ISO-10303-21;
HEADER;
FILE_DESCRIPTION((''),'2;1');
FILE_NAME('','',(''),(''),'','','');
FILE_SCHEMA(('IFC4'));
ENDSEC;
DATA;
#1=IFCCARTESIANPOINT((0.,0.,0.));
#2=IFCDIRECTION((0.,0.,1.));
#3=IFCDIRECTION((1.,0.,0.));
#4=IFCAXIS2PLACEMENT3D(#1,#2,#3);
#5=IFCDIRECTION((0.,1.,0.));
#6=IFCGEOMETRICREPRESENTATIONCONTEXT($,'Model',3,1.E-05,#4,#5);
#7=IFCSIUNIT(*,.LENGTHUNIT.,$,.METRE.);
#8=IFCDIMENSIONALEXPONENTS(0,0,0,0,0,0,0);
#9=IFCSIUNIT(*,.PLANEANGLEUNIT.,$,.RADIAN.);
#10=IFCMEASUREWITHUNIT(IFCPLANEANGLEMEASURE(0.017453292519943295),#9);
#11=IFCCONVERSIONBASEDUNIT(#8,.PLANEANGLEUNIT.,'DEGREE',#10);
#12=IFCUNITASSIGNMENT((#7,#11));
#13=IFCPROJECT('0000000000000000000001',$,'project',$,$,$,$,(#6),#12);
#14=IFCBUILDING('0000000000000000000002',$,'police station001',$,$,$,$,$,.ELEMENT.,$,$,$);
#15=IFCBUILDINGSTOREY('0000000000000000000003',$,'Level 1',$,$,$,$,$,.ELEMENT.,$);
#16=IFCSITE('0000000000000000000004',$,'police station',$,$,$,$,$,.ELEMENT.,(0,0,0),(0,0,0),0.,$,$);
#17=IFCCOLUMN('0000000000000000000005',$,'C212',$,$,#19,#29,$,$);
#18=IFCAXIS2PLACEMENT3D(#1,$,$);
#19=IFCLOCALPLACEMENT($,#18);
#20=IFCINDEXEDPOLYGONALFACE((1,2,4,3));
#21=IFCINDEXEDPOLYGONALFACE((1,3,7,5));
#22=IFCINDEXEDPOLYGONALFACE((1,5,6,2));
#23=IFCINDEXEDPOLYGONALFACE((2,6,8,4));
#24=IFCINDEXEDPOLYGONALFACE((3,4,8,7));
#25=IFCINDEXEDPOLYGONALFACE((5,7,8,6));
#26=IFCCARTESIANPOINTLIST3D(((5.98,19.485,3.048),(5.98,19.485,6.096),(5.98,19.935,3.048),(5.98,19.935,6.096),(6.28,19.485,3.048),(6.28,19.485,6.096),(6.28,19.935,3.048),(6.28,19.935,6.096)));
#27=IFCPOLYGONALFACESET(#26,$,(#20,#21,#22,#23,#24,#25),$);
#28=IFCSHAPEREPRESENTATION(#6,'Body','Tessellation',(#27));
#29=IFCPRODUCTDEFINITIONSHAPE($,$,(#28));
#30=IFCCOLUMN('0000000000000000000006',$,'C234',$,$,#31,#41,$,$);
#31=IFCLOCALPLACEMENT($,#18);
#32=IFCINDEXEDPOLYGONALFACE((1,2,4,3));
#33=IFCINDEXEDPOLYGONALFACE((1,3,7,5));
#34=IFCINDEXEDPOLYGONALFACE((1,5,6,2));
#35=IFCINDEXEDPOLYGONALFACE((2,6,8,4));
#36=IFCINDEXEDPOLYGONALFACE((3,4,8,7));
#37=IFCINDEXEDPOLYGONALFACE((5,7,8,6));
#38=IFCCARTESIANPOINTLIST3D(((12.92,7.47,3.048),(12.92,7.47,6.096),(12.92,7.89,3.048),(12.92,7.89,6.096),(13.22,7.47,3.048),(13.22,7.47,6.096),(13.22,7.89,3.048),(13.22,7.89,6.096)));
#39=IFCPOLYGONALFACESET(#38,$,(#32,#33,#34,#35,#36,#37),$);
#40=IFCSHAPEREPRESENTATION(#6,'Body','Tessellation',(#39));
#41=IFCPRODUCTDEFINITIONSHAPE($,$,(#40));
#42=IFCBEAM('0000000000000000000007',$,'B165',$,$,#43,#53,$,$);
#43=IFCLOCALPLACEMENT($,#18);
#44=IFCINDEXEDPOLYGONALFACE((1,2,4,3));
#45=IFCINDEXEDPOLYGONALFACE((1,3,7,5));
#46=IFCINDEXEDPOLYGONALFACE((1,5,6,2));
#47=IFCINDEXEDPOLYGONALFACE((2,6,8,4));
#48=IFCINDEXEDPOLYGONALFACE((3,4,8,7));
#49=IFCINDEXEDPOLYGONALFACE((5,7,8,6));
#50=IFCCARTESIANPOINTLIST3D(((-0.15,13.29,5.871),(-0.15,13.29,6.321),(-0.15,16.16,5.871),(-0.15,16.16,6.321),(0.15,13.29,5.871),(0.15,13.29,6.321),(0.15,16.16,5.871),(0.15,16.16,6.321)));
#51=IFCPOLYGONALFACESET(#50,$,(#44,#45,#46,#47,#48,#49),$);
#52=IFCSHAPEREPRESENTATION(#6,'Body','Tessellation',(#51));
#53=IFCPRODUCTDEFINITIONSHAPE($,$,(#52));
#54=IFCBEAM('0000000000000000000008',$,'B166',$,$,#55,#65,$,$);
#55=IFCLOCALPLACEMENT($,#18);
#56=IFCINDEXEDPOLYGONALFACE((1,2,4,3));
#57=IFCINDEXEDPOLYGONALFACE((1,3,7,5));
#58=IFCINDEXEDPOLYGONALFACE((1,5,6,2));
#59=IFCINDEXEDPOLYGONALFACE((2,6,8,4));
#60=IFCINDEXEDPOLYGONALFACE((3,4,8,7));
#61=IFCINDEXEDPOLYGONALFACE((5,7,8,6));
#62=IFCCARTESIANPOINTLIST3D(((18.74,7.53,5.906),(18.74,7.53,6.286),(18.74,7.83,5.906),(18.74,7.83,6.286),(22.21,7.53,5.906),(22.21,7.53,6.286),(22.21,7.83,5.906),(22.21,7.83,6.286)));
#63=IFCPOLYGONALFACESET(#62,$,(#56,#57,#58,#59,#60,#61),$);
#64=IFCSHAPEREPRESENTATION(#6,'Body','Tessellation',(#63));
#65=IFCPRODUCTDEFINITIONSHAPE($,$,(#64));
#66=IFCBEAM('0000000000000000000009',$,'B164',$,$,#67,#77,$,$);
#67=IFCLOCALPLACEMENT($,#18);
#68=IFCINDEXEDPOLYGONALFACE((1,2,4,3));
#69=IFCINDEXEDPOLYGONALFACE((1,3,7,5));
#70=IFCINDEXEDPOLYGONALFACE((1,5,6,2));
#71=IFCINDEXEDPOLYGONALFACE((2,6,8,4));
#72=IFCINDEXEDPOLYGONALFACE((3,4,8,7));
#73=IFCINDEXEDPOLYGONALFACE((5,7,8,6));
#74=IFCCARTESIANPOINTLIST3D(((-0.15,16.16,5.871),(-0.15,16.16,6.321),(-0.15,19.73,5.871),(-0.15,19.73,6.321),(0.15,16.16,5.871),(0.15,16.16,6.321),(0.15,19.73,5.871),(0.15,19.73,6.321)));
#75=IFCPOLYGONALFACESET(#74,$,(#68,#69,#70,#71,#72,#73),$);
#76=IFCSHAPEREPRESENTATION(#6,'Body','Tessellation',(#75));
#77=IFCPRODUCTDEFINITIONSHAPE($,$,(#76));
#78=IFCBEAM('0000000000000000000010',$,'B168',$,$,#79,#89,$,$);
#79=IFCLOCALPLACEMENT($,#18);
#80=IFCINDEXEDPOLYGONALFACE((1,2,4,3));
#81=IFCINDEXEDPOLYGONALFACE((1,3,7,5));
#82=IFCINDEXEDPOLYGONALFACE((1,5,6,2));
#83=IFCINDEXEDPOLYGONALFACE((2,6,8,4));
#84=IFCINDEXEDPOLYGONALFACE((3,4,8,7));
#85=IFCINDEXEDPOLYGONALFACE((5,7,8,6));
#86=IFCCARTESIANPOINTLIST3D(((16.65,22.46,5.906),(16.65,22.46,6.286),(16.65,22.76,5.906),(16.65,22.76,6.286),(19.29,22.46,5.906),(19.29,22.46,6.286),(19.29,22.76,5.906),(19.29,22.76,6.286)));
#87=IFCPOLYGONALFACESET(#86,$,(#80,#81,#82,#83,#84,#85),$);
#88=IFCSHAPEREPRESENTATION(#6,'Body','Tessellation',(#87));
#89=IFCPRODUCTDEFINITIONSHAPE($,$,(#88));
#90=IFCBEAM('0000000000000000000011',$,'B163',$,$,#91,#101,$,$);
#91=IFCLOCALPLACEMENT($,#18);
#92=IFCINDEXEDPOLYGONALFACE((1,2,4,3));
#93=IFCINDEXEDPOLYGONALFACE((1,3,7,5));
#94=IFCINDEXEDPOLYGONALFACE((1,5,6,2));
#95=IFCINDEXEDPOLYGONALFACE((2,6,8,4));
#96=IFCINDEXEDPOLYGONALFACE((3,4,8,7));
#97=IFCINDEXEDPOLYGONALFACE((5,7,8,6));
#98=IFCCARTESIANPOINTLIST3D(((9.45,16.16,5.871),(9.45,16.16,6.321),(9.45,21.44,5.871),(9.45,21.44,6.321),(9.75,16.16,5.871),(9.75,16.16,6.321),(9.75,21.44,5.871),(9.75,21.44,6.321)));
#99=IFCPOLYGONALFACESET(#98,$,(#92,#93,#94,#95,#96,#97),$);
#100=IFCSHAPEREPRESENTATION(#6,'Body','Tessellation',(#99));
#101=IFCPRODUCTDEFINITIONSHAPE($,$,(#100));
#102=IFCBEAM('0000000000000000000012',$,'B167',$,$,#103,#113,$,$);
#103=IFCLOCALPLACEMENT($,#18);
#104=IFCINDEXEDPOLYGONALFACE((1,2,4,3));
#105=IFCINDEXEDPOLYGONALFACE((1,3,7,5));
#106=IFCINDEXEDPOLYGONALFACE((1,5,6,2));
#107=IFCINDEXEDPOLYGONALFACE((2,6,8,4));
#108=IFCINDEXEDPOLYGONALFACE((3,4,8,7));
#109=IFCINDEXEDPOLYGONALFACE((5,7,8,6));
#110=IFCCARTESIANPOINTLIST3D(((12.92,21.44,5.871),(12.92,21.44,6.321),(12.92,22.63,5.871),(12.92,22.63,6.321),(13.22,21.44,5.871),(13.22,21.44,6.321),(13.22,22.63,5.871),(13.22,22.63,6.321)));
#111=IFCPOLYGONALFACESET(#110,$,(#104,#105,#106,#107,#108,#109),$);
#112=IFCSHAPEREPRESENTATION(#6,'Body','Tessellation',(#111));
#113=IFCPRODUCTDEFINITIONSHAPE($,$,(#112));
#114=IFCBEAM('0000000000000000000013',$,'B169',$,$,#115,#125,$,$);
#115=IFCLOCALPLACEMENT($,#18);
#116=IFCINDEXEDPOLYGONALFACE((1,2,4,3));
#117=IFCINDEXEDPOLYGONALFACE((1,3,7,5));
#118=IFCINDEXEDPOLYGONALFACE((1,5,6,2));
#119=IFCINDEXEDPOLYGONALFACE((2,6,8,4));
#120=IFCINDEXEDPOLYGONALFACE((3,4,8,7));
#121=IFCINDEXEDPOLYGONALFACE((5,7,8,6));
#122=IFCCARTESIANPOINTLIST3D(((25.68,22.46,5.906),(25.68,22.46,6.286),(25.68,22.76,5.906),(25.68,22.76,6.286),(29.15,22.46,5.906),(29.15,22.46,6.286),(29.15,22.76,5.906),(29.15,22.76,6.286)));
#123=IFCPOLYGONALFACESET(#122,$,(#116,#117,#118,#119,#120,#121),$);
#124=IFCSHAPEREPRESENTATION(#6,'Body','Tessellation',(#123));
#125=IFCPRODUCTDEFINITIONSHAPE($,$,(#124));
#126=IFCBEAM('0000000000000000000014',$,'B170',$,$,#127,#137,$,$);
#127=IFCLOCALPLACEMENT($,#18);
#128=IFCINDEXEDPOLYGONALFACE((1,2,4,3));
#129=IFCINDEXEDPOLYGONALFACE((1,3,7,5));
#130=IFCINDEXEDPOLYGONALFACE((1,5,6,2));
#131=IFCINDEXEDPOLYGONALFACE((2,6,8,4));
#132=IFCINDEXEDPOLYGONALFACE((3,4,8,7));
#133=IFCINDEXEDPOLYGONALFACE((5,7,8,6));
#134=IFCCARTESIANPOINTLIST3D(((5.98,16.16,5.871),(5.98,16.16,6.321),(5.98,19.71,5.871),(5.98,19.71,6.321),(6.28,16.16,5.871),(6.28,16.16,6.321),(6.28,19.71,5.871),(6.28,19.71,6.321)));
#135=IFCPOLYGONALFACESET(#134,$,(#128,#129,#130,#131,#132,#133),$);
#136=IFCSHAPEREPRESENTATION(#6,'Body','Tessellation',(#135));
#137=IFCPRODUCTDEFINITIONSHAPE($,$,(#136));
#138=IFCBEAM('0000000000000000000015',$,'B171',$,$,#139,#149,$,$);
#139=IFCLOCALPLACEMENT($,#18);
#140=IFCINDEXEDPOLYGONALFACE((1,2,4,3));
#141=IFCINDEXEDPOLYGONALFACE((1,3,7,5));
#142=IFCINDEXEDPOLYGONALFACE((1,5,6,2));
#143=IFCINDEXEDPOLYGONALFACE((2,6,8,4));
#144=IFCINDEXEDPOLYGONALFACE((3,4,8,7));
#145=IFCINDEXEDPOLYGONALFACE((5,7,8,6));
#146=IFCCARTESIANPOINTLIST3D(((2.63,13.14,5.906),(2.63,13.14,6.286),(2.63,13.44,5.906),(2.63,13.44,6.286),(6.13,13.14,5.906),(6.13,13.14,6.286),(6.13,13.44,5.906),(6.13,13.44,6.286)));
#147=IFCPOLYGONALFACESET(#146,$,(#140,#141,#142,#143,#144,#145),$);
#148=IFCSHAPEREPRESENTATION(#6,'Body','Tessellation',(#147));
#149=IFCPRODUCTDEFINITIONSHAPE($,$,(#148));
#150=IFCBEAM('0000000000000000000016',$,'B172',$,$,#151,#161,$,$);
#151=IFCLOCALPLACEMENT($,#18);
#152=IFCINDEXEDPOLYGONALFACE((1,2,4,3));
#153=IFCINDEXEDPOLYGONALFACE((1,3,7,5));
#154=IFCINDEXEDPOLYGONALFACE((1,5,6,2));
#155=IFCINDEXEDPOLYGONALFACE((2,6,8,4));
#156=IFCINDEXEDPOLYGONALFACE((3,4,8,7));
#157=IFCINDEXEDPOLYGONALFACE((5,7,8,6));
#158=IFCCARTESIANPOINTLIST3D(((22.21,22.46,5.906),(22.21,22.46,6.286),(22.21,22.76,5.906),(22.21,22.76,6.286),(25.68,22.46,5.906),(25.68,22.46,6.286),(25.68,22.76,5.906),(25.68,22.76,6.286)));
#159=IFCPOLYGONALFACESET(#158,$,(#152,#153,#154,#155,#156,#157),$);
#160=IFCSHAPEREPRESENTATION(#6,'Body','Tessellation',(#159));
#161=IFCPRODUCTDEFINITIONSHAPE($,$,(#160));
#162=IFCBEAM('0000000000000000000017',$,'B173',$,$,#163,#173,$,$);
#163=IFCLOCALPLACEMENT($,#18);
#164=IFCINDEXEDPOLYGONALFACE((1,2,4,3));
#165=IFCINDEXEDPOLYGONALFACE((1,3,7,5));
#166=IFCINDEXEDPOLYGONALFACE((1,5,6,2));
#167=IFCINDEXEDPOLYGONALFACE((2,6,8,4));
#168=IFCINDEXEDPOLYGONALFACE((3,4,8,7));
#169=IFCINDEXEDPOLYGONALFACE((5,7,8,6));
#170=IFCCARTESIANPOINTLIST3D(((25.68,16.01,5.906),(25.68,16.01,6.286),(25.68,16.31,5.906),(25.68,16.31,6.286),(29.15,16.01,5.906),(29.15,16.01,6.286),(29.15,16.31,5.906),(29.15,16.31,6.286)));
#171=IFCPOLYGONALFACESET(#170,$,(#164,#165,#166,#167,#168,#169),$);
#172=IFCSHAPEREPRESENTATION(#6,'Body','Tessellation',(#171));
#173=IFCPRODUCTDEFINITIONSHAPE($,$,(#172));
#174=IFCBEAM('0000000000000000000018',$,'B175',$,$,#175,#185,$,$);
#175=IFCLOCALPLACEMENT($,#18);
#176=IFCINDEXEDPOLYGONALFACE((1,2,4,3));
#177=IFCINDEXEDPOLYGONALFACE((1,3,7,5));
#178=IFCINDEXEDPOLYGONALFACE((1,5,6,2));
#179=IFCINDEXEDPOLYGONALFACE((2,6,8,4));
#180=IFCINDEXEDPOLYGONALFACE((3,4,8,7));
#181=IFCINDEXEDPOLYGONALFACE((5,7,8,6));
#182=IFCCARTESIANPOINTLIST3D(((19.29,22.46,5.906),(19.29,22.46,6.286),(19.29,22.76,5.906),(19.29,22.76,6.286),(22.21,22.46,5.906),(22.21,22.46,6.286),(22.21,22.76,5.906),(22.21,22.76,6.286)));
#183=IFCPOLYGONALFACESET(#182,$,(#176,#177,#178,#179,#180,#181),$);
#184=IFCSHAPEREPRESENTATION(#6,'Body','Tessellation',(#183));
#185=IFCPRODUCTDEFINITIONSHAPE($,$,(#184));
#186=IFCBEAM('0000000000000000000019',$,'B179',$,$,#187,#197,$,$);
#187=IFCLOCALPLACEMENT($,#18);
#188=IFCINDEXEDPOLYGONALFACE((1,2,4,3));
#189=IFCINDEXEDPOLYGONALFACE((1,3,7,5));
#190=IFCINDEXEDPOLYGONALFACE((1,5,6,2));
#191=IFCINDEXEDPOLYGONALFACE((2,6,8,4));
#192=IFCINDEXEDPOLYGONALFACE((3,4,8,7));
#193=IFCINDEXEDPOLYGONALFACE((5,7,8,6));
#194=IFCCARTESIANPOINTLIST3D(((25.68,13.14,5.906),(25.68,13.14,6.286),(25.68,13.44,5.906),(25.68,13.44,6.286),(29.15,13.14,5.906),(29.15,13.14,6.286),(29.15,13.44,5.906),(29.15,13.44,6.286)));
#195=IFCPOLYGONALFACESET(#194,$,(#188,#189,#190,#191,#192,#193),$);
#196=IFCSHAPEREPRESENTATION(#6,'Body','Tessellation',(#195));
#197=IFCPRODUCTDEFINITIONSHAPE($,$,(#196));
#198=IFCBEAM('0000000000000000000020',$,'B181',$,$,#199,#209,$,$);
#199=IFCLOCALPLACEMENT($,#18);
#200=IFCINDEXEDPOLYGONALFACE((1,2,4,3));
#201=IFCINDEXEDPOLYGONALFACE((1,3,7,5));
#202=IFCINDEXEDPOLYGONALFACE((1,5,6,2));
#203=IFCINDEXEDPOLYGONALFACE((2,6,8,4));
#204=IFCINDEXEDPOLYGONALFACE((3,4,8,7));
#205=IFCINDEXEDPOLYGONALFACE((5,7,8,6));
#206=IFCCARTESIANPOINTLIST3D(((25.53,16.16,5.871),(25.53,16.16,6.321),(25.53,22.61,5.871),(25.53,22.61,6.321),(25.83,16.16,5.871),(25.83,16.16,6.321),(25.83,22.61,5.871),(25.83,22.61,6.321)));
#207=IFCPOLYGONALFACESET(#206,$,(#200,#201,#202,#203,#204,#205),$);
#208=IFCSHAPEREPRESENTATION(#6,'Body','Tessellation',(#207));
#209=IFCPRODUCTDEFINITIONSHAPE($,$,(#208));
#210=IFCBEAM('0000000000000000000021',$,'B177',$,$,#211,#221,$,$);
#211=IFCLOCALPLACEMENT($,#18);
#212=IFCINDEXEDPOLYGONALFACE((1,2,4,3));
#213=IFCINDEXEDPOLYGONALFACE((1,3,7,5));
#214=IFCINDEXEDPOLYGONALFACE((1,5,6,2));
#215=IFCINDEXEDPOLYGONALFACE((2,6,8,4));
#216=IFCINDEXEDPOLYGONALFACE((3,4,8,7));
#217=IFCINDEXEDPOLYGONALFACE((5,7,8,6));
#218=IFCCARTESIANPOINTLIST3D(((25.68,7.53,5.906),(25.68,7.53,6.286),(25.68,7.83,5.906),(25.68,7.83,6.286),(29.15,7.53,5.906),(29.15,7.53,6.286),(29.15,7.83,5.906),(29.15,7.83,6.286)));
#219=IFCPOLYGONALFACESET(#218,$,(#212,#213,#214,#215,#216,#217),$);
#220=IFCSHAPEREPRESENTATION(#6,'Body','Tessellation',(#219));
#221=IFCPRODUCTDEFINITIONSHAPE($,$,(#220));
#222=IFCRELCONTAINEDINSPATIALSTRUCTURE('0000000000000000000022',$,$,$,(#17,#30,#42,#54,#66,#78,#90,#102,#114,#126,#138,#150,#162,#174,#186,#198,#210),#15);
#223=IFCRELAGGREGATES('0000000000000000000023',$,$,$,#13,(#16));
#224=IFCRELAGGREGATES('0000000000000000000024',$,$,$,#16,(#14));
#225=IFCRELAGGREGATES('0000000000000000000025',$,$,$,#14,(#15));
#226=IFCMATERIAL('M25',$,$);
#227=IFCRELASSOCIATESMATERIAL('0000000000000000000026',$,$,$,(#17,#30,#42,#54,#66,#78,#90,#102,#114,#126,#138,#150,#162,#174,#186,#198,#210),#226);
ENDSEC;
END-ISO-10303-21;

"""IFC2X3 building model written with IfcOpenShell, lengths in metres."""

from ifc_helpers import new_model, entity, si_unit, converted_unit, direction, frame, frame_2d, origin_with_axes, place, context, project, spatial, rectangle, extrude, material, element, save


model = new_model("IFC2X3")

# Units and contexts
model_context = context("Model", 3, precision=1e-05, world=origin_with_axes(), true_north=direction((0.0, 1.0, 0.0)))
ifc_project = project(units=[si_unit("LENGTHUNIT", "METRE"), converted_unit("PLANEANGLEUNIT", "DEGREE", entity("IfcPlaneAngleMeasure", 0.017453292519943295), si_unit("PLANEANGLEUNIT", "RADIAN"), dimensions=[0, 0, 0, 0, 0, 0, 0])], contexts=[model_context])

# Site, building, storey
site = spatial("IfcSite", under=ifc_project, Name="police station", CompositionType="ELEMENT", RefLatitude=(0, 0, 0), RefLongitude=(0, 0, 0), RefElevation=0.0)
building = spatial("IfcBuilding", under=site, Name="police station001", CompositionType="ELEMENT")
storey = spatial("IfcBuildingStorey", under=building, Name="Level 1", CompositionType="ELEMENT")

# Columns
ifc_material = material(Name="M25")
placement = place(None, origin_with_axes())
element("IfcColumn", 1, at=placement, inside=storey, material=ifc_material, Name="C212", context=model_context, shape_type="SweptSolid", body=[
    extrude(rectangle(XDim=0.3, YDim=0.45, at=frame_2d((0.0, 0.0), x_axis=(1.0, 0.0, 0.0))), frame((6.13, 19.71, 3.048), z_axis=(0.0, 0.0, 1.0), x_axis=(1.0, 0.0, 0.0)), (0.0, 0.0, 1.0), 3.048),
])
element("IfcColumn", 2, at=placement, inside=storey, material=ifc_material, Name="C234", context=model_context, shape_type="SweptSolid", body=[
    extrude(rectangle(XDim=0.3, YDim=0.42, at=frame_2d((0.0, 0.0), x_axis=(1.0, 0.0, 0.0))), frame((13.07, 7.68, 3.048), z_axis=(0.0, 0.0, 1.0), x_axis=(1.0, 0.0, 0.0)), (0.0, 0.0, 1.0), 3.048),
])

# Beams
element("IfcBeam", 3, at=placement, inside=storey, material=ifc_material, Name="B165", context=model_context, shape_type="SweptSolid", body=[
    extrude(rectangle(XDim=0.3, YDim=0.45, at=frame_2d((0.0, 0.0), x_axis=(0.0, 1.0, 0.0))), frame((0.0, 13.29, 6.096), z_axis=(0.0, 1.0, 0.0), x_axis=(0.0, 0.0, -1.0)), (0.0, 0.0, 1.0), 2.87),
])
element("IfcBeam", 4, at=placement, inside=storey, material=ifc_material, Name="B166", context=model_context, shape_type="SweptSolid", body=[
    extrude(rectangle(XDim=0.3, YDim=0.38, at=frame_2d((0.0, 0.0), x_axis=(0.0, 1.0, 0.0))), frame((18.74, 7.68, 6.096), z_axis=(1.0, 0.0, 0.0), x_axis=(0.0, 0.0, -1.0)), (0.0, 0.0, 1.0), 3.47),
])
element("IfcBeam", 5, at=placement, inside=storey, material=ifc_material, Name="B164", context=model_context, shape_type="SweptSolid", body=[
    extrude(rectangle(XDim=0.3, YDim=0.45, at=frame_2d((0.0, 0.0), x_axis=(0.0, 1.0, 0.0))), frame((0.0, 19.73, 6.096), z_axis=(0.0, -1.0, 0.0), x_axis=(0.0, 0.0, -1.0)), (0.0, 0.0, 1.0), 3.57),
])
element("IfcBeam", 6, at=placement, inside=storey, material=ifc_material, Name="B168", context=model_context, shape_type="SweptSolid", body=[
    extrude(rectangle(XDim=0.3, YDim=0.38, at=frame_2d((0.0, 0.0), x_axis=(0.0, 1.0, 0.0))), frame((19.29, 22.61, 6.096), z_axis=(-1.0, 0.0, 0.0), x_axis=(0.0, 0.0, -1.0)), (0.0, 0.0, 1.0), 2.64),
])
element("IfcBeam", 7, at=placement, inside=storey, material=ifc_material, Name="B163", context=model_context, shape_type="SweptSolid", body=[
    extrude(rectangle(XDim=0.3, YDim=0.45, at=frame_2d((0.0, 0.0), x_axis=(0.0, 1.0, 0.0))), frame((9.6, 16.16, 6.096), z_axis=(0.0, 1.0, 0.0), x_axis=(0.0, 0.0, -1.0)), (0.0, 0.0, 1.0), 5.28),
])
element("IfcBeam", 8, at=placement, inside=storey, material=ifc_material, Name="B167", context=model_context, shape_type="SweptSolid", body=[
    extrude(rectangle(XDim=0.3, YDim=0.45, at=frame_2d((0.0, 0.0), x_axis=(0.0, 1.0, 0.0))), frame((13.07, 21.44, 6.096), z_axis=(0.0, 1.0, 0.0), x_axis=(0.0, 0.0, -1.0)), (0.0, 0.0, 1.0), 1.19),
])
element("IfcBeam", 9, at=placement, inside=storey, material=ifc_material, Name="B169", context=model_context, shape_type="SweptSolid", body=[
    extrude(rectangle(XDim=0.3, YDim=0.38, at=frame_2d((0.0, 0.0), x_axis=(0.0, 1.0, 0.0))), frame((29.15, 22.61, 6.096), z_axis=(-1.0, 0.0, 0.0), x_axis=(0.0, 0.0, -1.0)), (0.0, 0.0, 1.0), 3.47),
])
element("IfcBeam", 10, at=placement, inside=storey, material=ifc_material, Name="B170", context=model_context, shape_type="SweptSolid", body=[
    extrude(rectangle(XDim=0.3, YDim=0.45, at=frame_2d((0.0, 0.0), x_axis=(0.0, 1.0, 0.0))), frame((6.13, 16.16, 6.096), z_axis=(0.0, 1.0, 0.0), x_axis=(0.0, 0.0, -1.0)), (0.0, 0.0, 1.0), 3.55),
])
element("IfcBeam", 11, at=placement, inside=storey, material=ifc_material, Name="B171", context=model_context, shape_type="SweptSolid", body=[
    extrude(rectangle(XDim=0.3, YDim=0.38, at=frame_2d((0.0, 0.0), x_axis=(0.0, 1.0, 0.0))), frame((2.63, 13.29, 6.096), z_axis=(1.0, 0.0, 0.0), x_axis=(0.0, 0.0, -1.0)), (0.0, 0.0, 1.0), 3.5),
])
element("IfcBeam", 12, at=placement, inside=storey, material=ifc_material, Name="B172", context=model_context, shape_type="SweptSolid", body=[
    extrude(rectangle(XDim=0.3, YDim=0.38, at=frame_2d((0.0, 0.0), x_axis=(0.0, 1.0, 0.0))), frame((25.68, 22.61, 6.096), z_axis=(-1.0, 0.0, 0.0), x_axis=(0.0, 0.0, -1.0)), (0.0, 0.0, 1.0), 3.47),
])
element("IfcBeam", 13, at=placement, inside=storey, material=ifc_material, Name="B173", context=model_context, shape_type="SweptSolid", body=[
    extrude(rectangle(XDim=0.3, YDim=0.38, at=frame_2d((0.0, 0.0), x_axis=(0.0, 1.0, 0.0))), frame((25.68, 16.16, 6.096), z_axis=(1.0, 0.0, 0.0), x_axis=(0.0, 0.0, -1.0)), (0.0, 0.0, 1.0), 3.47),
])
element("IfcBeam", 14, at=placement, inside=storey, material=ifc_material, Name="B175", context=model_context, shape_type="SweptSolid", body=[
    extrude(rectangle(XDim=0.3, YDim=0.38, at=frame_2d((0.0, 0.0), x_axis=(0.0, 1.0, 0.0))), frame((22.21, 22.61, 6.096), z_axis=(-1.0, 0.0, 0.0), x_axis=(0.0, 0.0, -1.0)), (0.0, 0.0, 1.0), 2.92),
])
element("IfcBeam", 15, at=placement, inside=storey, material=ifc_material, Name="B179", context=model_context, shape_type="SweptSolid", body=[
    extrude(rectangle(XDim=0.3, YDim=0.38, at=frame_2d((0.0, 0.0), x_axis=(0.0, 1.0, 0.0))), frame((29.15, 13.29, 6.096), z_axis=(-1.0, 0.0, 0.0), x_axis=(0.0, 0.0, -1.0)), (0.0, 0.0, 1.0), 3.47),
])
element("IfcBeam", 16, at=placement, inside=storey, material=ifc_material, Name="B181", context=model_context, shape_type="SweptSolid", body=[
    extrude(rectangle(XDim=0.3, YDim=0.45, at=frame_2d((0.0, 0.0), x_axis=(0.0, 1.0, 0.0))), frame((25.68, 22.61, 6.096), z_axis=(0.0, -1.0, 0.0), x_axis=(0.0, 0.0, -1.0)), (0.0, 0.0, 1.0), 6.45),
])
element("IfcBeam", 17, at=placement, inside=storey, material=ifc_material, Name="B177", context=model_context, shape_type="SweptSolid", body=[
    extrude(rectangle(XDim=0.3, YDim=0.38, at=frame_2d((0.0, 0.0), x_axis=(0.0, 1.0, 0.0))), frame((25.68, 7.68, 6.096), z_axis=(1.0, 0.0, 0.0), x_axis=(0.0, 0.0, -1.0)), (0.0, 0.0, 1.0), 3.47),
])

save(model, "model.ifc")
